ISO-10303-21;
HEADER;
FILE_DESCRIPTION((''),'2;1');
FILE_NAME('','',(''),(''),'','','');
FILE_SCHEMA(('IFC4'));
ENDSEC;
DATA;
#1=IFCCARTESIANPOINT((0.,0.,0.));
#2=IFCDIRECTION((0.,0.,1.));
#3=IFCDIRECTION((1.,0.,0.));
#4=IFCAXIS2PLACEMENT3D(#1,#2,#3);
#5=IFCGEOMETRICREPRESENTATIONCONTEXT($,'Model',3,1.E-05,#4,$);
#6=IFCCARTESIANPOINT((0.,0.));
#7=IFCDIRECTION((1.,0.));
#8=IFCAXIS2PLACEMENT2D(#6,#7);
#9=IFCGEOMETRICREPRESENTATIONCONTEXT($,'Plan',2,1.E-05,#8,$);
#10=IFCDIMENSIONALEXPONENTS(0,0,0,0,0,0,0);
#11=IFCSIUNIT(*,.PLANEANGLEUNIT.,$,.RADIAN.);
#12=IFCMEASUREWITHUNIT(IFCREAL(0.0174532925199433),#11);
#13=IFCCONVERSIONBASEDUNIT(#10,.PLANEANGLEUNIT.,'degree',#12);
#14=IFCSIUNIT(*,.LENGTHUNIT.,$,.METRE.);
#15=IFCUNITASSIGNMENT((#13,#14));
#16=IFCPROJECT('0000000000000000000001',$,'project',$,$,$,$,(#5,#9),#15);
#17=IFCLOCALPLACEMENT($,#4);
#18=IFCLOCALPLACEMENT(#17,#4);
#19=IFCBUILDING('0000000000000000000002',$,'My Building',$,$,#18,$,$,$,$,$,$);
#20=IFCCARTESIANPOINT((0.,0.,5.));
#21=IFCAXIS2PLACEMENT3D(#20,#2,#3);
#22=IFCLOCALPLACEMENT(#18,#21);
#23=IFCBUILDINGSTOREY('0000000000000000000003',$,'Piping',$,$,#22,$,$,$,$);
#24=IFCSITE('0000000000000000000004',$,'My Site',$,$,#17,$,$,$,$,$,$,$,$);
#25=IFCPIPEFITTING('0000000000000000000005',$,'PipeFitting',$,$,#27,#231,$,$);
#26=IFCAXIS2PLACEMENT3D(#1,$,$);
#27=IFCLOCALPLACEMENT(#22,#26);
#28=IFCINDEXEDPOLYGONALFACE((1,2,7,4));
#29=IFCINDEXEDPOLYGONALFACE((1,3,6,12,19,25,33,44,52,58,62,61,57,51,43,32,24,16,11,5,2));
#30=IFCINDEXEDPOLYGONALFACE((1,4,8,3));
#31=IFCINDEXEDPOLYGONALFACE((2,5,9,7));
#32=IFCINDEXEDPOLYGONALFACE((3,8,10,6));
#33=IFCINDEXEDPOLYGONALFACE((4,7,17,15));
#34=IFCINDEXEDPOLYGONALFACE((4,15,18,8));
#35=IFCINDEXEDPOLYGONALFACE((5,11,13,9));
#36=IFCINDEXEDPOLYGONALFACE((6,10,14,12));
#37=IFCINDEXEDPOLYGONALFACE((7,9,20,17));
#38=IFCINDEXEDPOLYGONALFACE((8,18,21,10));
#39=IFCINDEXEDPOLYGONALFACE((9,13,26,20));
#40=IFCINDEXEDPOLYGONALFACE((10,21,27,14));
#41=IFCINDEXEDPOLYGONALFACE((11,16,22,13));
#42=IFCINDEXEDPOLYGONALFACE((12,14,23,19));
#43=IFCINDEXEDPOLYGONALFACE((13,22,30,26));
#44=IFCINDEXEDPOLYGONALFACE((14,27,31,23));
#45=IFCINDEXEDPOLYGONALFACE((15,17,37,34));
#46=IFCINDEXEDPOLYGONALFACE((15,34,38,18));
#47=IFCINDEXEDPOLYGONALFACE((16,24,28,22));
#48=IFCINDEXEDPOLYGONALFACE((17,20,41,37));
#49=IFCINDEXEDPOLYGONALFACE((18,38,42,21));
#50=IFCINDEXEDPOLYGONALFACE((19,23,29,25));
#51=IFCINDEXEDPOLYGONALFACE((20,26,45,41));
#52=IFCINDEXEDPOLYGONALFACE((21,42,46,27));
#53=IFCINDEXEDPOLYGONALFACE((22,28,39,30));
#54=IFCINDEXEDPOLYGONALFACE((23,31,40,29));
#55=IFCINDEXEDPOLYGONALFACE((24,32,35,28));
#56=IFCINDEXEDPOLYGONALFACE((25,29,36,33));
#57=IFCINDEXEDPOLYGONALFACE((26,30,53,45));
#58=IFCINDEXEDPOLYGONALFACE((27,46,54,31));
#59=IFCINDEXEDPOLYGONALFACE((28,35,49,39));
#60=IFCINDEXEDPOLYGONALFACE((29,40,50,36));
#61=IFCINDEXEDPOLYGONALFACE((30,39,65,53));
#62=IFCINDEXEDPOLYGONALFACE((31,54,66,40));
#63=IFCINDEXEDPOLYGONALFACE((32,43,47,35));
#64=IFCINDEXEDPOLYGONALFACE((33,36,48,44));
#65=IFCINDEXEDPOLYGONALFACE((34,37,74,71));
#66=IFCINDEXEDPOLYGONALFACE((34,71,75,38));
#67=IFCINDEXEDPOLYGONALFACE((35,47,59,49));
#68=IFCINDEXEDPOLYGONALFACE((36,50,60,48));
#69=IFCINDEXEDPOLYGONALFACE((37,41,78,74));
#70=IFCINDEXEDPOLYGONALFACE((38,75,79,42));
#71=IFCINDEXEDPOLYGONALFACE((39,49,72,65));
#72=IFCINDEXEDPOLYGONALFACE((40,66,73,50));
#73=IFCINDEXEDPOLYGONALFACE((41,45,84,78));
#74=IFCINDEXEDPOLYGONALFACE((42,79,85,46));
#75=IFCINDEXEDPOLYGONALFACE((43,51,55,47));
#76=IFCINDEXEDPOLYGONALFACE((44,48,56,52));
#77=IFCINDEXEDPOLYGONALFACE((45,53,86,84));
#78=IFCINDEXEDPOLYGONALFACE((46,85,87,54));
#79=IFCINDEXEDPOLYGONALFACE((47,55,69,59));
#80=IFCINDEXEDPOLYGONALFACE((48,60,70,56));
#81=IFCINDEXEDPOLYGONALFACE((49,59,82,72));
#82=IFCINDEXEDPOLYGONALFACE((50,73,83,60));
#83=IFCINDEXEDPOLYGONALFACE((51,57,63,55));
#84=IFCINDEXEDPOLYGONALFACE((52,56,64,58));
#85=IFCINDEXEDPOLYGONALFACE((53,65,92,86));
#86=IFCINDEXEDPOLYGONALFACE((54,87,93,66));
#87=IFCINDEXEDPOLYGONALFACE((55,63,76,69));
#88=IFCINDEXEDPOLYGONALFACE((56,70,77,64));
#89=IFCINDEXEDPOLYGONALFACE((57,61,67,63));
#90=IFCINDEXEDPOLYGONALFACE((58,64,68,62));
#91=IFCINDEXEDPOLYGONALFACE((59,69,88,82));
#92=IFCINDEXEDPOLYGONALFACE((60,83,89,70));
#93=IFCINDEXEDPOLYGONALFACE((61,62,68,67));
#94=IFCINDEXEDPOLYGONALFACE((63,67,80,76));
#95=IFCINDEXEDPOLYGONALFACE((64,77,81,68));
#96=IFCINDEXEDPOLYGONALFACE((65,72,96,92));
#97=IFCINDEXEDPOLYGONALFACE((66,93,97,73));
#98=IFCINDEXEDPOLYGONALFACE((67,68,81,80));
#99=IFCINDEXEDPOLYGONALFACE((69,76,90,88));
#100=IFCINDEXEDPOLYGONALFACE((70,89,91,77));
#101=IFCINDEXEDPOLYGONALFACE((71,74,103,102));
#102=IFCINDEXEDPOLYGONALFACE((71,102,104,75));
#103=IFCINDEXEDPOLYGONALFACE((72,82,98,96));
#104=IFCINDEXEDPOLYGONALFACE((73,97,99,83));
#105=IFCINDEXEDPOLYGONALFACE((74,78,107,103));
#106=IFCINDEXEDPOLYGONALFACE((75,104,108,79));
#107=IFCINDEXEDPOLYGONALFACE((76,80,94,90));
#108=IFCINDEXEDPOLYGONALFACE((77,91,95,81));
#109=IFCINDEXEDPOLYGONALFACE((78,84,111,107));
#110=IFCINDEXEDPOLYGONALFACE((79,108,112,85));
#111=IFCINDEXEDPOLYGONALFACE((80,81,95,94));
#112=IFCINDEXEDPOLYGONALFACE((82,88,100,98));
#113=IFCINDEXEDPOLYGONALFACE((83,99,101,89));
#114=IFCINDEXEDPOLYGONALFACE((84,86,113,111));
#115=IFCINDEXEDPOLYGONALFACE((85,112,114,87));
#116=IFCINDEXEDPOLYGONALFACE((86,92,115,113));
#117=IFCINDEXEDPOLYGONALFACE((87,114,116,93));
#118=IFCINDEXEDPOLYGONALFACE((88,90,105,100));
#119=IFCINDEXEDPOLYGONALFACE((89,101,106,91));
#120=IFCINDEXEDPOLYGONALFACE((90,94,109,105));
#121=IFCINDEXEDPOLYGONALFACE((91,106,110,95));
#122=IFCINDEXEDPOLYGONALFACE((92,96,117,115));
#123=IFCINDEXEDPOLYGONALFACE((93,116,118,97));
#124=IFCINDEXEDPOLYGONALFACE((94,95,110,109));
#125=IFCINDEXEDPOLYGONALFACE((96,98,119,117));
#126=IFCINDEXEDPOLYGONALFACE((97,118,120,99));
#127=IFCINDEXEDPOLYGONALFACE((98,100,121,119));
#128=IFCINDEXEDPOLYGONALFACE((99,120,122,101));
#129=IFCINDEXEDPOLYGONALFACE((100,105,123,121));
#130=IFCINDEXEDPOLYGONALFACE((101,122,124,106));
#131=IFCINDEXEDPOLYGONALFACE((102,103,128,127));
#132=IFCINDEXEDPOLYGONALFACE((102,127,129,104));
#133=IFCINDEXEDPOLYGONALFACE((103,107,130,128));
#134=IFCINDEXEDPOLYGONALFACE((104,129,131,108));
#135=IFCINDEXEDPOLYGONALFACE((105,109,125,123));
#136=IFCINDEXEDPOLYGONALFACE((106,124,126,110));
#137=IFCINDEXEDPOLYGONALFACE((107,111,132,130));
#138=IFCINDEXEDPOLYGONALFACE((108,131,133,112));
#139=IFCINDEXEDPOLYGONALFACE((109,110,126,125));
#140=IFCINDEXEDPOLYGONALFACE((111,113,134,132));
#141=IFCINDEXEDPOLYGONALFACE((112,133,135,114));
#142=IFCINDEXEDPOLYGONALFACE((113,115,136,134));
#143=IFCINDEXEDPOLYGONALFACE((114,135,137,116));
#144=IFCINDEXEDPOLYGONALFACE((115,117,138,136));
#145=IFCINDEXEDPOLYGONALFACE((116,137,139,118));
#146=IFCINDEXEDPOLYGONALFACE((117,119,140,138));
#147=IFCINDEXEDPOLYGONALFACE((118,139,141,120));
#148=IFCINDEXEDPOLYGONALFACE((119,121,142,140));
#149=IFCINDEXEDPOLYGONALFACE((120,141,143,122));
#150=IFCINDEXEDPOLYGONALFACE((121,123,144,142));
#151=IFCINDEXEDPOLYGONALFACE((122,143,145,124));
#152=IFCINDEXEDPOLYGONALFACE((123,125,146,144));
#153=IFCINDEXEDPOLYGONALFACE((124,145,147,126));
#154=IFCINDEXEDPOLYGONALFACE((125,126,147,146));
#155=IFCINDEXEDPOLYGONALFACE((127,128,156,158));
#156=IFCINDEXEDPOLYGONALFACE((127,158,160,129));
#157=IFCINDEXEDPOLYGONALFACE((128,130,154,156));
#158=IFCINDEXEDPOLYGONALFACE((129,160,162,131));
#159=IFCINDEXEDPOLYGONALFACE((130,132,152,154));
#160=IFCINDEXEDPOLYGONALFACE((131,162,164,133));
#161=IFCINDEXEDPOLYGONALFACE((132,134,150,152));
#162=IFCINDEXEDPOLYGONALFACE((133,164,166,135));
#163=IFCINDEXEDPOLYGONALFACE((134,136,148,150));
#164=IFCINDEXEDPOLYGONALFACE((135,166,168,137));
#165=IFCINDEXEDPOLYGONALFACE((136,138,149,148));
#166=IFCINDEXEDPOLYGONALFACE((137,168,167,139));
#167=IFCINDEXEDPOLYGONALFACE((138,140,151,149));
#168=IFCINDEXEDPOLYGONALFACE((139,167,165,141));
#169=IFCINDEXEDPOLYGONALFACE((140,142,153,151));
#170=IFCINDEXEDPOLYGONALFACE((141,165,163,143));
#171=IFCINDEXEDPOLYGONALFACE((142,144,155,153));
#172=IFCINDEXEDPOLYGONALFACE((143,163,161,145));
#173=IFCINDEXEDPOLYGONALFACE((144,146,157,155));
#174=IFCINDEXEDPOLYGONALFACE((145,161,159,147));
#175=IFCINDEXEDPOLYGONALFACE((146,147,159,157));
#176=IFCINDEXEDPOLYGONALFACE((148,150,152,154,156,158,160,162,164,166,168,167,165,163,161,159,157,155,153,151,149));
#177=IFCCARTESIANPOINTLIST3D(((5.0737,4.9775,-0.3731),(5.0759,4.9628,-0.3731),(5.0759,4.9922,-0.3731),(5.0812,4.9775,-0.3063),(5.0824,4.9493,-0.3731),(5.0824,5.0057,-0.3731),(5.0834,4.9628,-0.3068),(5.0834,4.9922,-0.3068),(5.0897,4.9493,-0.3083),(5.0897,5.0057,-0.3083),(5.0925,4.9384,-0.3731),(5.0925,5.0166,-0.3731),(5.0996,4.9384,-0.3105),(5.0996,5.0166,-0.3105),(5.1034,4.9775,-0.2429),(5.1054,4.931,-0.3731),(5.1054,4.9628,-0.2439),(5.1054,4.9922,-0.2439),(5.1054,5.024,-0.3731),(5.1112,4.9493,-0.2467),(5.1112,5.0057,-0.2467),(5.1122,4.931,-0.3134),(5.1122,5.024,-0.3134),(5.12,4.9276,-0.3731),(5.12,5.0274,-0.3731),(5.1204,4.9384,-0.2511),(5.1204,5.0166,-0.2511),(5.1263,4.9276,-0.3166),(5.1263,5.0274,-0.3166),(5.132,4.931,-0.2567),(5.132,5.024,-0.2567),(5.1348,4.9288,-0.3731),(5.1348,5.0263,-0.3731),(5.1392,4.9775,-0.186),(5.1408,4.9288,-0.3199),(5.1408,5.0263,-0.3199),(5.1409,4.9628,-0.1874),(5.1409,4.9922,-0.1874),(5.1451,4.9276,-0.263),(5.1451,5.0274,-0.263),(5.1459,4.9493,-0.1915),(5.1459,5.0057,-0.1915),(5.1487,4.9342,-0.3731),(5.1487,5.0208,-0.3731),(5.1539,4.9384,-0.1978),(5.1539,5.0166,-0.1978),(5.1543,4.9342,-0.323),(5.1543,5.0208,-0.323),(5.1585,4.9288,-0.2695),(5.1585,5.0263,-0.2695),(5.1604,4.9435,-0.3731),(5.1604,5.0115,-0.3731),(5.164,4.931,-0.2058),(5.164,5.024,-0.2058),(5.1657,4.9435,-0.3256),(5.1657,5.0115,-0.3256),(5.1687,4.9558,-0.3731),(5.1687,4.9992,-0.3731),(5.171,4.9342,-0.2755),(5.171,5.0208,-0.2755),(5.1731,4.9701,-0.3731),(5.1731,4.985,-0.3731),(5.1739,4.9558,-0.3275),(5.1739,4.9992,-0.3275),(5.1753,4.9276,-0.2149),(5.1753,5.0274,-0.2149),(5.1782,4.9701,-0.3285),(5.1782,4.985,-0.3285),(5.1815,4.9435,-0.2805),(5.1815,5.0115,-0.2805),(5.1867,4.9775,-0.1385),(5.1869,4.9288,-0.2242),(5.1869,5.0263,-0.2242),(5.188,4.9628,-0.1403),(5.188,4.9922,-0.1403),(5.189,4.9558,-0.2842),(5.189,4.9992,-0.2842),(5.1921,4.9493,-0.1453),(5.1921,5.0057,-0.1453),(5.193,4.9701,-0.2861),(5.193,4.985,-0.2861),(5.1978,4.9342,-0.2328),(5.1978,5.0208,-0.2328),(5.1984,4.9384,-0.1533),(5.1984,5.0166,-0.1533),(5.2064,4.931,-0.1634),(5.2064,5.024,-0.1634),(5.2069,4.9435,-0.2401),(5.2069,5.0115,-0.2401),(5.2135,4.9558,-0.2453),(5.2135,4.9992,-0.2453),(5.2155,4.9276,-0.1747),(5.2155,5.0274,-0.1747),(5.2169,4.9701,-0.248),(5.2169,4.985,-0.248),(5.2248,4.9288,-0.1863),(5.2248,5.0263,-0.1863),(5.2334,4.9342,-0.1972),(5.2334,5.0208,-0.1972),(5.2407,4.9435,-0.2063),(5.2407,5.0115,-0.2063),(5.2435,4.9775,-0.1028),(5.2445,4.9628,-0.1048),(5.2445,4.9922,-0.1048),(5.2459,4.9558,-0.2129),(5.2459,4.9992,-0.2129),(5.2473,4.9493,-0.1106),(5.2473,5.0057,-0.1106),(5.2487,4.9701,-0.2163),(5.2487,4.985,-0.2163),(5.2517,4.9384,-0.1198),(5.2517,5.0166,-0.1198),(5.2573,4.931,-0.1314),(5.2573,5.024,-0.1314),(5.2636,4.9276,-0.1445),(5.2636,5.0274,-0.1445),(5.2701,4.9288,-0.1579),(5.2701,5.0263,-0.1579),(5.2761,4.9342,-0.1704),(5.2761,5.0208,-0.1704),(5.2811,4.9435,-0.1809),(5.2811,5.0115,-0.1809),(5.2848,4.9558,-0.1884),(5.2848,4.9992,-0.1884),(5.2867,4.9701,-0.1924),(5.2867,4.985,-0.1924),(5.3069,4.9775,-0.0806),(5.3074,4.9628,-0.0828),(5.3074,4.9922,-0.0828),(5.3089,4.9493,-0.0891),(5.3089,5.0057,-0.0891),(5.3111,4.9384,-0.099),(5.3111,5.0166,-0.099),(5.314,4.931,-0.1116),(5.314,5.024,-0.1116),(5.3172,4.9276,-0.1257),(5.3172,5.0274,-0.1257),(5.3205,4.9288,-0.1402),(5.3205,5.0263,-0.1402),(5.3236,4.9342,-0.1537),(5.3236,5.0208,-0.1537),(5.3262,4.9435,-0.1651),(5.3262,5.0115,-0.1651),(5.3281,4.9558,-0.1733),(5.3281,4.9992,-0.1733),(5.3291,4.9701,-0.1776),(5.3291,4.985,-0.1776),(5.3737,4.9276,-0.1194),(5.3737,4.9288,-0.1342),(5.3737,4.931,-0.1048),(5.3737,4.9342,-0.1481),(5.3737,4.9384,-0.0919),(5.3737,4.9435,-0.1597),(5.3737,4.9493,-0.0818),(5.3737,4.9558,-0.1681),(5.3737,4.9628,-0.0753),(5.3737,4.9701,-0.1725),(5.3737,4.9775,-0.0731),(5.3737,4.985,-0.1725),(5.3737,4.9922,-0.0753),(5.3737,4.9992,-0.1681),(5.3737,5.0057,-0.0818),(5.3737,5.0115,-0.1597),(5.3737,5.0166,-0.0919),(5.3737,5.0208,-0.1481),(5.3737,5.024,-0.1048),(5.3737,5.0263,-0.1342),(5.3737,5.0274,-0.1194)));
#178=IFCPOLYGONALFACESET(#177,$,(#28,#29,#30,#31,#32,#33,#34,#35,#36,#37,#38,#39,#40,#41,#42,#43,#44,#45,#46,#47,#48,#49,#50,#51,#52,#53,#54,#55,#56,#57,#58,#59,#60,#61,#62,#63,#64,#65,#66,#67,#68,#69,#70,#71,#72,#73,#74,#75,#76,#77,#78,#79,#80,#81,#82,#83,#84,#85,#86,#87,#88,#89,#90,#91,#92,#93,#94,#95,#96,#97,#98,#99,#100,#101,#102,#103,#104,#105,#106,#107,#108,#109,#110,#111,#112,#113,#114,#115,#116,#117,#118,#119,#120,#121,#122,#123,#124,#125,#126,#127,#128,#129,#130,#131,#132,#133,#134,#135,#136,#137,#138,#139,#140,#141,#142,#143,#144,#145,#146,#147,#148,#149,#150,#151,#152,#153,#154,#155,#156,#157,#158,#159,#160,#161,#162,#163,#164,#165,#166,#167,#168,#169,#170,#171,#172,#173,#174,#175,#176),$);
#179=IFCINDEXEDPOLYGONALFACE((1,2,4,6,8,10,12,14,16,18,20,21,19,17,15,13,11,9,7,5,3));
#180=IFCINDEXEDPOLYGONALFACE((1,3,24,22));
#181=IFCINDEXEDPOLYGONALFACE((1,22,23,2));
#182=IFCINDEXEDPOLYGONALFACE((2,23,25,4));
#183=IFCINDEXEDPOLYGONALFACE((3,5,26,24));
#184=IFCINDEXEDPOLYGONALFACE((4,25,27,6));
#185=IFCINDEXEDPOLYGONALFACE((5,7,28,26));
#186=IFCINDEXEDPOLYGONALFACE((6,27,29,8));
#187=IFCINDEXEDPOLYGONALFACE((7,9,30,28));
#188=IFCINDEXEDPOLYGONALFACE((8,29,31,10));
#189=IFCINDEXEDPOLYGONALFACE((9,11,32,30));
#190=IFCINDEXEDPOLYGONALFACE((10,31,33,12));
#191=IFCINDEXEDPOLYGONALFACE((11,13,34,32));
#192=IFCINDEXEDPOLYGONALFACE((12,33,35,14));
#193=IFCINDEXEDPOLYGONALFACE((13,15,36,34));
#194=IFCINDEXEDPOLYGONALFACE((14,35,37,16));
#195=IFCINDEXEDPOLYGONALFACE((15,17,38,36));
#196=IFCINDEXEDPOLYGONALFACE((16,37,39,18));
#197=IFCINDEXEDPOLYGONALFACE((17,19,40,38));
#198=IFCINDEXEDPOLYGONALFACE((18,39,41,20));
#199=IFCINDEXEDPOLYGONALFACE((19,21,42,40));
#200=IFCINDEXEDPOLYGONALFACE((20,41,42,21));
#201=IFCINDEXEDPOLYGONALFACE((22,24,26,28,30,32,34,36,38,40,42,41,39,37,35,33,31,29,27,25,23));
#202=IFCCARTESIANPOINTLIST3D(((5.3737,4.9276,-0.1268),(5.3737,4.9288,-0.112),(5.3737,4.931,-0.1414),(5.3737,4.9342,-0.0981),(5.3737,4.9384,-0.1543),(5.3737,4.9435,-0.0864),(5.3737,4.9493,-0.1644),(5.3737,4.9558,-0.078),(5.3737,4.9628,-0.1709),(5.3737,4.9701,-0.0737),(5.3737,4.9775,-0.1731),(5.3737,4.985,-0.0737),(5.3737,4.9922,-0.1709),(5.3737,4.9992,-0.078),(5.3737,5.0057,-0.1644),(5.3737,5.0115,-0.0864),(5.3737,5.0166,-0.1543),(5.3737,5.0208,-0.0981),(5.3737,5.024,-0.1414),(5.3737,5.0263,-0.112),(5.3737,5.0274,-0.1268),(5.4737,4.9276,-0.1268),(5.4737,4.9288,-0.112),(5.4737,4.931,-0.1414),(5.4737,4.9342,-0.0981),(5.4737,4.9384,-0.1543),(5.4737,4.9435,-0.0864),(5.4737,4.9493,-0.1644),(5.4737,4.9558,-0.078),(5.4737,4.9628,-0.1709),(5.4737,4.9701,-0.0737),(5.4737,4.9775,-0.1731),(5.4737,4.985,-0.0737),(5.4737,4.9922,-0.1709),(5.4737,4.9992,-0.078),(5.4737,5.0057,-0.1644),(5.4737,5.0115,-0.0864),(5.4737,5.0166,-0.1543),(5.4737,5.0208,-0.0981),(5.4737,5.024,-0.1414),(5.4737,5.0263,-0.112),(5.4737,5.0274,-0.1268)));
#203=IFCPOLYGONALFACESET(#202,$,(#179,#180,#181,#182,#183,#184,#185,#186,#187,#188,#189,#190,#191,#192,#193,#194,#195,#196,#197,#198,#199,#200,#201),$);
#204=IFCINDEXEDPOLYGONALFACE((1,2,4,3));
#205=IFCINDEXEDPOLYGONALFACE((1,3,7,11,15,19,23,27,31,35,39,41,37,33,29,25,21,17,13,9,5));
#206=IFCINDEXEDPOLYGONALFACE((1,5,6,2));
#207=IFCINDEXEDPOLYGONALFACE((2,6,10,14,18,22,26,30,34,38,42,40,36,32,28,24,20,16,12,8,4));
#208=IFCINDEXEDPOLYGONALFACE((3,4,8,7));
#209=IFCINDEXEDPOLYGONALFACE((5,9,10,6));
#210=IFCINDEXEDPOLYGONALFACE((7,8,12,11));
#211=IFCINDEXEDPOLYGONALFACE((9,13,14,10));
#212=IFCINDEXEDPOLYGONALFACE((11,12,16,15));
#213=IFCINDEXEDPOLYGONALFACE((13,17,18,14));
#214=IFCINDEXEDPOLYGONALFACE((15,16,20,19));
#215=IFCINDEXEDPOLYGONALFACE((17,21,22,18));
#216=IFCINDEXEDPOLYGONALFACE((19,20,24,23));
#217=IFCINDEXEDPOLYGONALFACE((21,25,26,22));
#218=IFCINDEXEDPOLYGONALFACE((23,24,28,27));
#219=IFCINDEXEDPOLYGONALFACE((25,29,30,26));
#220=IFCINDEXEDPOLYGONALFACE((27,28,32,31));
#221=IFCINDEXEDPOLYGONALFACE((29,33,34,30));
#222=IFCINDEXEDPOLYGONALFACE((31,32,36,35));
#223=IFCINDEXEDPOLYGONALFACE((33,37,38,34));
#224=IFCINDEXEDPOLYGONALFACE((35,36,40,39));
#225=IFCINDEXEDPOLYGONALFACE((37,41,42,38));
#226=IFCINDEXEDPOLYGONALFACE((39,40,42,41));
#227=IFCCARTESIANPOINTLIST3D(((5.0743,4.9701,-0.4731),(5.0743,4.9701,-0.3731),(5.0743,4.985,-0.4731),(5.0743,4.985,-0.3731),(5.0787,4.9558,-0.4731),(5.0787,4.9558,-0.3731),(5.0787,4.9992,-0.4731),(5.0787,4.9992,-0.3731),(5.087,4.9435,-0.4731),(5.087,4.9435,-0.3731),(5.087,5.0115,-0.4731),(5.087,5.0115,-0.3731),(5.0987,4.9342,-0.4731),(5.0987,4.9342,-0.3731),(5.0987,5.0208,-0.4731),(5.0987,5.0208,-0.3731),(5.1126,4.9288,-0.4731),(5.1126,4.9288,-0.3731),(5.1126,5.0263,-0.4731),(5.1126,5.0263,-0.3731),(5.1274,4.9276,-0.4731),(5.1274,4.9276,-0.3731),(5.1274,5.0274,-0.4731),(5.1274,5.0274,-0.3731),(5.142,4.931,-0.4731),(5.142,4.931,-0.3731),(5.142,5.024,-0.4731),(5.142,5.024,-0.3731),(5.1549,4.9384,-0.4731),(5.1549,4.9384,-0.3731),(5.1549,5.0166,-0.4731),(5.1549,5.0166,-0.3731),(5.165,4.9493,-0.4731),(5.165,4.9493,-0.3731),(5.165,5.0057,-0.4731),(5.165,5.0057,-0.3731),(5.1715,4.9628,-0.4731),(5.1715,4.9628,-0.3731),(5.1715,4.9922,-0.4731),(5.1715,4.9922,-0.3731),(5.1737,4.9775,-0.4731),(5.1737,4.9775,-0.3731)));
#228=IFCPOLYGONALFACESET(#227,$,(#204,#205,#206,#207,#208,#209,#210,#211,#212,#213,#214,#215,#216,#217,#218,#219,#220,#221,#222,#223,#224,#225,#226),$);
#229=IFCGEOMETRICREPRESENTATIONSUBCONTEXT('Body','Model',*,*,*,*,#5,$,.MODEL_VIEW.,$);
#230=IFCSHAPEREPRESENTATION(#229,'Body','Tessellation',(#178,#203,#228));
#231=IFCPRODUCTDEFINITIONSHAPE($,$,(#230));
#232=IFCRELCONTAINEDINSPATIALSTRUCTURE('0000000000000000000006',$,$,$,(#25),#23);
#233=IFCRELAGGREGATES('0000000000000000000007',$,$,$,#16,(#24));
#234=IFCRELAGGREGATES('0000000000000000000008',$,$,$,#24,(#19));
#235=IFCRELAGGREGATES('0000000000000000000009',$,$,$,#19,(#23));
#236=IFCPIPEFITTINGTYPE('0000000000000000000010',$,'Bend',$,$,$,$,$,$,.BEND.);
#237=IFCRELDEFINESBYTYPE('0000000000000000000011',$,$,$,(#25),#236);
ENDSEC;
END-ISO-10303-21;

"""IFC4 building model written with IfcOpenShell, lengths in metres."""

from ifc_helpers import new_model, entity, si_unit, converted_unit, frame, origin_with_axes, origin_2d_with_axis, place, context, subcontext, project, spatial, circle, extrude, source, transform, mapped, type_object, type_shapes, element, save


model = new_model("IFC4")

# Units and contexts
model_context = context("Model", 3, precision=1e-05, world=origin_with_axes())
plan_context = context("Plan", 2, precision=1e-05, world=origin_2d_with_axis())
body_context = subcontext(model_context, "Body", "Model", "MODEL_VIEW")
ifc_project = project(units=[converted_unit("PLANEANGLEUNIT", "degree", entity("IfcReal", 0.0174532925199433), si_unit("PLANEANGLEUNIT", "RADIAN"), dimensions=[0, 0, 0, 0, 0, 0, 0]), si_unit("LENGTHUNIT", "METRE")], contexts=[model_context, plan_context])

# Site, building, storey
site_placement = place(None, origin_with_axes())
site = spatial("IfcSite", under=ifc_project, at=site_placement, Name="My Site")
building_placement = place(site_placement, origin_with_axes())
building = spatial("IfcBuilding", under=site, at=building_placement, Name="My Building")
storey_placement = place(building_placement, frame((0.0, 0.0, 5.0), z_axis=(0.0, 0.0, 1.0), x_axis=(1.0, 0.0, 0.0)))
storey = spatial("IfcBuildingStorey", under=building, at=storey_placement, Name="Piping")

# Pipe fitting
pipe_fitting_type_1 = type_object("IfcPipeFittingType", Name="Bend", PredefinedType="BEND")
shared_shape = source(origin_with_axes(), body_context, "Body", "SolidModel", [
    entity("IfcSweptDiskSolid", entity("IfcIndexedPolyCurve", entity("IfcCartesianPointList3D", [[0.0, 0.0, -0.1], [0.0732, 0.0, -0.2768], [0.25, 0.0, -0.35]]), [entity("IfcArcIndex", [1, 2, 3])]), 0.05),
    extrude(circle(Radius=0.05), origin_with_axes(), (0.0, 0.0, -1.0), 0.1),
    extrude(circle(Radius=0.05), frame((0.25, 0.0, -0.35), z_axis=(1.0, 0.0, 0.0), x_axis=(0.0, 0.0, 1.0)), (0.0, 0.0, 1.0), 0.1),
])
type_shapes(pipe_fitting_type_1, [shared_shape])
for number, where, z_axis, x_axis, name in (
    (1, (5.4737, 4.9775, -0.1231), (1.0, 0.000001, 0.0), (0.0, 0.0, -1.0), "PipeFitting"),
):
    element("IfcPipeFitting", number, at=place(storey_placement, frame(where, z_axis=z_axis, x_axis=x_axis)), inside=storey, type_object=pipe_fitting_type_1, Name=name, context=body_context, shape_type="MappedRepresentation", body=[
        mapped(shared_shape, transform((0.0, 0.0, 0.0), x_axis=(1.0, 0.0, 0.0), y_axis=(0.0, 1.0, 0.0), z_axis=(0.0, 0.0, 1.0), scale=1.0)),
    ])

save(model, "model.ifc")
